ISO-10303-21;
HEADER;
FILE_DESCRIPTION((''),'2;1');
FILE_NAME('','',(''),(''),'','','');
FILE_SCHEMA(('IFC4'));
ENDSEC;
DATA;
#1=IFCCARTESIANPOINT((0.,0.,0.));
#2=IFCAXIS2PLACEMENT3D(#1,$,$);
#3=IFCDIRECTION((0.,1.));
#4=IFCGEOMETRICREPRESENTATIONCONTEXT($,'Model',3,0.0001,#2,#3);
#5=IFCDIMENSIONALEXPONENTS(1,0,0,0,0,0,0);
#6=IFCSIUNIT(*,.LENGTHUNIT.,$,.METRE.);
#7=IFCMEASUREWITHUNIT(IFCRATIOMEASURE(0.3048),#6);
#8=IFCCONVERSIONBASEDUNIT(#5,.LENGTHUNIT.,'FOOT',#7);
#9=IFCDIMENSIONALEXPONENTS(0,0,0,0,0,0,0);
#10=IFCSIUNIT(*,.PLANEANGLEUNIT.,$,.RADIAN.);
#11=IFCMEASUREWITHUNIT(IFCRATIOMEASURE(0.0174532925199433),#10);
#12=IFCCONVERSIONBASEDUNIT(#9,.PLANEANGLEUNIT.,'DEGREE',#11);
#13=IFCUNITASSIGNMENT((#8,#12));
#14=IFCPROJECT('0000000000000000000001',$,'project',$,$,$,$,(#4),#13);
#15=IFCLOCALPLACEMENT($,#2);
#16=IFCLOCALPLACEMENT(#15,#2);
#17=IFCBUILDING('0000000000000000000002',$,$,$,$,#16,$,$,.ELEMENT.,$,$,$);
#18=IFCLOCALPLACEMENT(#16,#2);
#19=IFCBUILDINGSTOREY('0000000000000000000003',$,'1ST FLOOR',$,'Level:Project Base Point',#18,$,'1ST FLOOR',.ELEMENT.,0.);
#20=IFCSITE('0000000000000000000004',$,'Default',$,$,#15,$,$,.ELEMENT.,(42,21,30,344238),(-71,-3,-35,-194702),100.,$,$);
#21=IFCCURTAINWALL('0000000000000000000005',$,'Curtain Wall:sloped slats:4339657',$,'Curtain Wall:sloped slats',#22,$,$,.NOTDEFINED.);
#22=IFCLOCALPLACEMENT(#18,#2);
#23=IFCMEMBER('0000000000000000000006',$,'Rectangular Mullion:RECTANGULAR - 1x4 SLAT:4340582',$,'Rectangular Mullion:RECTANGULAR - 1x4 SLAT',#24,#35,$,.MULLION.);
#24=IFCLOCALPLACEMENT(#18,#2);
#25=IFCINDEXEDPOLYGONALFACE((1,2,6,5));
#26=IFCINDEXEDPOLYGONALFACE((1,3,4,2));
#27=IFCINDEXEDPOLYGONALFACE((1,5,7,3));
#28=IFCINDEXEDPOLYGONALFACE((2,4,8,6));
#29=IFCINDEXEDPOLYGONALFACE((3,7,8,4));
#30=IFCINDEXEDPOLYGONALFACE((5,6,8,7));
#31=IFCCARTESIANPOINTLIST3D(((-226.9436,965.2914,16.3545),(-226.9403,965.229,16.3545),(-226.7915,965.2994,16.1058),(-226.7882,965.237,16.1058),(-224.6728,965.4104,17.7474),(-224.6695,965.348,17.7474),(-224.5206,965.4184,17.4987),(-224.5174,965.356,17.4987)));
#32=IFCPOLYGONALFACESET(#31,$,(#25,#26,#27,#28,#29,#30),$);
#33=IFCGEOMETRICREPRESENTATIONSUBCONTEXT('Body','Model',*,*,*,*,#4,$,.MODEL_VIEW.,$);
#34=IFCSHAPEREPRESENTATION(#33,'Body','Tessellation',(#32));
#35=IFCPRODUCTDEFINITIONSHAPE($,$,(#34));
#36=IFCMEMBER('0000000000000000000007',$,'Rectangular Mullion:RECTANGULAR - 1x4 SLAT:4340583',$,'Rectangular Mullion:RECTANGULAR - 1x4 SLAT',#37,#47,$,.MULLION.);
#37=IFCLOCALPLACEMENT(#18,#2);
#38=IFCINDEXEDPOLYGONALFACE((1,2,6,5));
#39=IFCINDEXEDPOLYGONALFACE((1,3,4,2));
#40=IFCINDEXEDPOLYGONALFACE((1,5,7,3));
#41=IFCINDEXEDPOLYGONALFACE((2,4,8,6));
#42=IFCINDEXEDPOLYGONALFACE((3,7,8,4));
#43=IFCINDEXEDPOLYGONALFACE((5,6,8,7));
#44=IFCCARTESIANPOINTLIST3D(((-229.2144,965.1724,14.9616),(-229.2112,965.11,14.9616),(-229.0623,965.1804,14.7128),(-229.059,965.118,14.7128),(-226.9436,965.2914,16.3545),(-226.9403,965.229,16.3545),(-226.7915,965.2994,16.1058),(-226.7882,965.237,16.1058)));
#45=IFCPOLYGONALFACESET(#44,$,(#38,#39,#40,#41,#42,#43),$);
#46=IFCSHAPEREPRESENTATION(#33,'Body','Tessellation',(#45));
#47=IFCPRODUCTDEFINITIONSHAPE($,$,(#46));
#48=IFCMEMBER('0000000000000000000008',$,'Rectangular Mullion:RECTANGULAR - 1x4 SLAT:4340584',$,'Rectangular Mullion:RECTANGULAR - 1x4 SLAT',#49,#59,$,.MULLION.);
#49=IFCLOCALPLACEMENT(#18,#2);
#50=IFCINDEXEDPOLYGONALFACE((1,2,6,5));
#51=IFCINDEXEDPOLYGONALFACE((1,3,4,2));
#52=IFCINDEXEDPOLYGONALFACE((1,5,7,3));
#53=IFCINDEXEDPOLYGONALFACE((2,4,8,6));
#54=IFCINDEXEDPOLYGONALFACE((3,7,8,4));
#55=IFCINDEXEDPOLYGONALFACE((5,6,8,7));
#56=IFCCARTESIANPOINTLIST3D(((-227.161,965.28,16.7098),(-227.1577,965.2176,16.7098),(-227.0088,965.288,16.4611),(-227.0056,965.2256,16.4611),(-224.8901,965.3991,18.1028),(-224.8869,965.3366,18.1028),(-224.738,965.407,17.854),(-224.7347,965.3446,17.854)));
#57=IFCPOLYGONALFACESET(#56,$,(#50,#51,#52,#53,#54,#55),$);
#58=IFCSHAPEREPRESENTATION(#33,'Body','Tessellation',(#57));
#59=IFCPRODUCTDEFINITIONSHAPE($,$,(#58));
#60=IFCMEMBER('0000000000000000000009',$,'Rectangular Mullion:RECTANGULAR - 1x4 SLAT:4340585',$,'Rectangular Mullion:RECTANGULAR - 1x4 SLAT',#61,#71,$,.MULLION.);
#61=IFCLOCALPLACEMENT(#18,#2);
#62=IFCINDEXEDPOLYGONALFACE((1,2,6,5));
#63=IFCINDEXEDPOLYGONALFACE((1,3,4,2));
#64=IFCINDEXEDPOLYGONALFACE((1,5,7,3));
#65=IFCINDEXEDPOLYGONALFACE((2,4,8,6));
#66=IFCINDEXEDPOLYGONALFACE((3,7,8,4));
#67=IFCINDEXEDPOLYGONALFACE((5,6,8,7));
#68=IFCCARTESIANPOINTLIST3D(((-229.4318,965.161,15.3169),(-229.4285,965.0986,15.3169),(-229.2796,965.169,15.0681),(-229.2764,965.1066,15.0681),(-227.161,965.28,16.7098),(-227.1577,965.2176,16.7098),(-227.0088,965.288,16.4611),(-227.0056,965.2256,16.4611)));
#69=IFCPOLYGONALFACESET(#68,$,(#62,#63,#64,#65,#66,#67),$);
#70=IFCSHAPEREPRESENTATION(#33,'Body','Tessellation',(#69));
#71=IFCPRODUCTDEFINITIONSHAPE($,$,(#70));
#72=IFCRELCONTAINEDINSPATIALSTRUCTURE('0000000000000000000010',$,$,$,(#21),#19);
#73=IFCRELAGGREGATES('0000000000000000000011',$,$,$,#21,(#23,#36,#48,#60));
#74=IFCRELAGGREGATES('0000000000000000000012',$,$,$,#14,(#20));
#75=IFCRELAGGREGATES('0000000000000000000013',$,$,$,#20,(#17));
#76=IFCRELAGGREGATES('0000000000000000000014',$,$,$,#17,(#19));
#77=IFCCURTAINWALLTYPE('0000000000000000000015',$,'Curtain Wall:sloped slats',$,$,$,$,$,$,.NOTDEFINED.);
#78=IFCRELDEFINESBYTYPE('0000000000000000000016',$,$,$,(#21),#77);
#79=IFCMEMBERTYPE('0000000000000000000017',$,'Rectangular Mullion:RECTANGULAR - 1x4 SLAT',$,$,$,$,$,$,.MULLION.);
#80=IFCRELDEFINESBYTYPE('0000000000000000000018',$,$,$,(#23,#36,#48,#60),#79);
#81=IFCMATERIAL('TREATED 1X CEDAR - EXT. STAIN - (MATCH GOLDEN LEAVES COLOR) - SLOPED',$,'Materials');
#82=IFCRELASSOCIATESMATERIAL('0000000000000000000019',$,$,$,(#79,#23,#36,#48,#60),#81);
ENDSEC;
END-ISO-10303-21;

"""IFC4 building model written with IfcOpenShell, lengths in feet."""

from ifc_helpers import new_model, entity, si_unit, converted_unit, direction, frame, frame_2d, origin, place, context, subcontext, project, spatial, rectangle, extrude, source, transform, mapped, material, material_profile, profile_set, profile_usage, type_object, type_shapes, element, aggregate, save


model = new_model("IFC4")

# Units and contexts
model_context = context("Model", 3, precision=0.0001, world=origin(), true_north=direction((0.0, 1.0)))
body_context = subcontext(model_context, "Body", "Model", "MODEL_VIEW")
ifc_project = project(units=[converted_unit("LENGTHUNIT", "FOOT", entity("IfcRatioMeasure", 0.3048), si_unit("LENGTHUNIT", "METRE"), dimensions=[1, 0, 0, 0, 0, 0, 0]), converted_unit("PLANEANGLEUNIT", "DEGREE", entity("IfcRatioMeasure", 0.0174532925199433), si_unit("PLANEANGLEUNIT", "RADIAN"), dimensions=[0, 0, 0, 0, 0, 0, 0])], contexts=[model_context])

# Site, building, storey
site_placement = place(None, origin())
site = spatial("IfcSite", under=ifc_project, at=site_placement, Name="Default", CompositionType="ELEMENT", RefLatitude=(42, 21, 30, 344238), RefLongitude=(-71, -3, -35, -194702), RefElevation=100.0)
building_placement = place(site_placement, origin())
building = spatial("IfcBuilding", under=site, at=building_placement, CompositionType="ELEMENT")
storey_placement = place(building_placement, origin())
storey = spatial("IfcBuildingStorey", under=building, at=storey_placement, Name="1ST FLOOR", ObjectType="Level:Project Base Point", LongName="1ST FLOOR", CompositionType="ELEMENT", Elevation=0.0)

# Curtain wall, members
curtain_wall_type_1 = type_object("IfcCurtainWallType", Name="Curtain Wall:sloped slats", PredefinedType="NOTDEFINED")
ifc_material_1 = material(Name="TREATED 1X CEDAR - EXT. STAIN - (MATCH GOLDEN LEAVES COLOR) - SLOPED", Category="Materials")
ifc_material_profile_1 = material_profile(ifc_material_1, rectangle(XDim=0.0625, YDim=0.2917, at=frame_2d((0.0, 0.0), x_axis=(1.0, 0.0))), Name="RECTANGULAR - 1x4 SLAT")
ifc_profile_set_1 = profile_set([ifc_material_profile_1], Name="RECTANGULAR - 1x4 SLAT")
member_type_1 = type_object("IfcMemberType", Name="Rectangular Mullion:RECTANGULAR - 1x4 SLAT", PredefinedType="MULLION", material=ifc_profile_set_1)
shared_shape_1 = source(origin(), body_context, "Body", "SweptSolid", [
    extrude(rectangle(XDim=0.0625, YDim=0.2917, at=frame_2d((0.0, 0.0), x_axis=(1.0, 0.0))), frame((0.0, 0.0, -2.6667), z_axis=(0.0, 0.0, 1.0), x_axis=(0.0, -1.0, 0.0)), (0.0, 0.0, 1.0), 2.6667),
])
type_shapes(member_type_1, [shared_shape_1])
curtain_wall_1_placement = place(storey_placement, origin())
curtain_wall_1 = element("IfcCurtainWall", 1, at=curtain_wall_1_placement, inside=storey, type_object=curtain_wall_type_1, Name="Curtain Wall:sloped slats:4339657", ObjectType="Curtain Wall:sloped slats", PredefinedType="NOTDEFINED")
ifc_profile_usage_1 = profile_usage(ifc_profile_set_1)
member_1_placement = place(storey_placement, frame((-226.8659, 965.2642, 16.2301), z_axis=(-0.851559, -0.044628, -0.522356), x_axis=(-0.52164, -0.027338, 0.852727)))
member_1 = element("IfcMember", 2, at=member_1_placement, type_object=member_type_1, material=ifc_profile_usage_1, Name="Rectangular Mullion:RECTANGULAR - 1x4 SLAT:4340582", ObjectType="Rectangular Mullion:RECTANGULAR - 1x4 SLAT", PredefinedType="MULLION", context=body_context, shape_type="MappedRepresentation", body=[
    mapped(shared_shape_1, transform((0.0, 0.0, 0.0), scale=1.0)),
])
ifc_profile_usage_2 = profile_usage(ifc_profile_set_1)
member_2_placement = place(storey_placement, frame((-229.1367, 965.1452, 14.8372), z_axis=(-0.851559, -0.044628, -0.522356), x_axis=(-0.52164, -0.027338, 0.852727)))
member_2 = element("IfcMember", 3, at=member_2_placement, type_object=member_type_1, material=ifc_profile_usage_2, Name="Rectangular Mullion:RECTANGULAR - 1x4 SLAT:4340583", ObjectType="Rectangular Mullion:RECTANGULAR - 1x4 SLAT", PredefinedType="MULLION", context=body_context, shape_type="MappedRepresentation", body=[
    mapped(shared_shape_1, transform((0.0, 0.0, 0.0), scale=1.0)),
])
ifc_profile_usage_3 = profile_usage(ifc_profile_set_1)
member_3_placement = place(storey_placement, frame((-227.0833, 965.2528, 16.5854), z_axis=(-0.851559, -0.044628, -0.522356), x_axis=(-0.52164, -0.027338, 0.852727)))
member_3 = element("IfcMember", 4, at=member_3_placement, type_object=member_type_1, material=ifc_profile_usage_3, Name="Rectangular Mullion:RECTANGULAR - 1x4 SLAT:4340584", ObjectType="Rectangular Mullion:RECTANGULAR - 1x4 SLAT", PredefinedType="MULLION", context=body_context, shape_type="MappedRepresentation", body=[
    mapped(shared_shape_1, transform((0.0, 0.0, 0.0), scale=1.0)),
])
ifc_profile_usage_4 = profile_usage(ifc_profile_set_1)
member_4_placement = place(storey_placement, frame((-229.3541, 965.1338, 15.1925), z_axis=(-0.851559, -0.044628, -0.522356), x_axis=(-0.52164, -0.027338, 0.852727)))
member_4 = element("IfcMember", 5, at=member_4_placement, type_object=member_type_1, material=ifc_profile_usage_4, Name="Rectangular Mullion:RECTANGULAR - 1x4 SLAT:4340585", ObjectType="Rectangular Mullion:RECTANGULAR - 1x4 SLAT", PredefinedType="MULLION", context=body_context, shape_type="MappedRepresentation", body=[
    mapped(shared_shape_1, transform((0.0, 0.0, 0.0), scale=1.0)),
])
aggregate(curtain_wall_1, [member_1, member_2, member_3, member_4])

save(model, "model.ifc")
